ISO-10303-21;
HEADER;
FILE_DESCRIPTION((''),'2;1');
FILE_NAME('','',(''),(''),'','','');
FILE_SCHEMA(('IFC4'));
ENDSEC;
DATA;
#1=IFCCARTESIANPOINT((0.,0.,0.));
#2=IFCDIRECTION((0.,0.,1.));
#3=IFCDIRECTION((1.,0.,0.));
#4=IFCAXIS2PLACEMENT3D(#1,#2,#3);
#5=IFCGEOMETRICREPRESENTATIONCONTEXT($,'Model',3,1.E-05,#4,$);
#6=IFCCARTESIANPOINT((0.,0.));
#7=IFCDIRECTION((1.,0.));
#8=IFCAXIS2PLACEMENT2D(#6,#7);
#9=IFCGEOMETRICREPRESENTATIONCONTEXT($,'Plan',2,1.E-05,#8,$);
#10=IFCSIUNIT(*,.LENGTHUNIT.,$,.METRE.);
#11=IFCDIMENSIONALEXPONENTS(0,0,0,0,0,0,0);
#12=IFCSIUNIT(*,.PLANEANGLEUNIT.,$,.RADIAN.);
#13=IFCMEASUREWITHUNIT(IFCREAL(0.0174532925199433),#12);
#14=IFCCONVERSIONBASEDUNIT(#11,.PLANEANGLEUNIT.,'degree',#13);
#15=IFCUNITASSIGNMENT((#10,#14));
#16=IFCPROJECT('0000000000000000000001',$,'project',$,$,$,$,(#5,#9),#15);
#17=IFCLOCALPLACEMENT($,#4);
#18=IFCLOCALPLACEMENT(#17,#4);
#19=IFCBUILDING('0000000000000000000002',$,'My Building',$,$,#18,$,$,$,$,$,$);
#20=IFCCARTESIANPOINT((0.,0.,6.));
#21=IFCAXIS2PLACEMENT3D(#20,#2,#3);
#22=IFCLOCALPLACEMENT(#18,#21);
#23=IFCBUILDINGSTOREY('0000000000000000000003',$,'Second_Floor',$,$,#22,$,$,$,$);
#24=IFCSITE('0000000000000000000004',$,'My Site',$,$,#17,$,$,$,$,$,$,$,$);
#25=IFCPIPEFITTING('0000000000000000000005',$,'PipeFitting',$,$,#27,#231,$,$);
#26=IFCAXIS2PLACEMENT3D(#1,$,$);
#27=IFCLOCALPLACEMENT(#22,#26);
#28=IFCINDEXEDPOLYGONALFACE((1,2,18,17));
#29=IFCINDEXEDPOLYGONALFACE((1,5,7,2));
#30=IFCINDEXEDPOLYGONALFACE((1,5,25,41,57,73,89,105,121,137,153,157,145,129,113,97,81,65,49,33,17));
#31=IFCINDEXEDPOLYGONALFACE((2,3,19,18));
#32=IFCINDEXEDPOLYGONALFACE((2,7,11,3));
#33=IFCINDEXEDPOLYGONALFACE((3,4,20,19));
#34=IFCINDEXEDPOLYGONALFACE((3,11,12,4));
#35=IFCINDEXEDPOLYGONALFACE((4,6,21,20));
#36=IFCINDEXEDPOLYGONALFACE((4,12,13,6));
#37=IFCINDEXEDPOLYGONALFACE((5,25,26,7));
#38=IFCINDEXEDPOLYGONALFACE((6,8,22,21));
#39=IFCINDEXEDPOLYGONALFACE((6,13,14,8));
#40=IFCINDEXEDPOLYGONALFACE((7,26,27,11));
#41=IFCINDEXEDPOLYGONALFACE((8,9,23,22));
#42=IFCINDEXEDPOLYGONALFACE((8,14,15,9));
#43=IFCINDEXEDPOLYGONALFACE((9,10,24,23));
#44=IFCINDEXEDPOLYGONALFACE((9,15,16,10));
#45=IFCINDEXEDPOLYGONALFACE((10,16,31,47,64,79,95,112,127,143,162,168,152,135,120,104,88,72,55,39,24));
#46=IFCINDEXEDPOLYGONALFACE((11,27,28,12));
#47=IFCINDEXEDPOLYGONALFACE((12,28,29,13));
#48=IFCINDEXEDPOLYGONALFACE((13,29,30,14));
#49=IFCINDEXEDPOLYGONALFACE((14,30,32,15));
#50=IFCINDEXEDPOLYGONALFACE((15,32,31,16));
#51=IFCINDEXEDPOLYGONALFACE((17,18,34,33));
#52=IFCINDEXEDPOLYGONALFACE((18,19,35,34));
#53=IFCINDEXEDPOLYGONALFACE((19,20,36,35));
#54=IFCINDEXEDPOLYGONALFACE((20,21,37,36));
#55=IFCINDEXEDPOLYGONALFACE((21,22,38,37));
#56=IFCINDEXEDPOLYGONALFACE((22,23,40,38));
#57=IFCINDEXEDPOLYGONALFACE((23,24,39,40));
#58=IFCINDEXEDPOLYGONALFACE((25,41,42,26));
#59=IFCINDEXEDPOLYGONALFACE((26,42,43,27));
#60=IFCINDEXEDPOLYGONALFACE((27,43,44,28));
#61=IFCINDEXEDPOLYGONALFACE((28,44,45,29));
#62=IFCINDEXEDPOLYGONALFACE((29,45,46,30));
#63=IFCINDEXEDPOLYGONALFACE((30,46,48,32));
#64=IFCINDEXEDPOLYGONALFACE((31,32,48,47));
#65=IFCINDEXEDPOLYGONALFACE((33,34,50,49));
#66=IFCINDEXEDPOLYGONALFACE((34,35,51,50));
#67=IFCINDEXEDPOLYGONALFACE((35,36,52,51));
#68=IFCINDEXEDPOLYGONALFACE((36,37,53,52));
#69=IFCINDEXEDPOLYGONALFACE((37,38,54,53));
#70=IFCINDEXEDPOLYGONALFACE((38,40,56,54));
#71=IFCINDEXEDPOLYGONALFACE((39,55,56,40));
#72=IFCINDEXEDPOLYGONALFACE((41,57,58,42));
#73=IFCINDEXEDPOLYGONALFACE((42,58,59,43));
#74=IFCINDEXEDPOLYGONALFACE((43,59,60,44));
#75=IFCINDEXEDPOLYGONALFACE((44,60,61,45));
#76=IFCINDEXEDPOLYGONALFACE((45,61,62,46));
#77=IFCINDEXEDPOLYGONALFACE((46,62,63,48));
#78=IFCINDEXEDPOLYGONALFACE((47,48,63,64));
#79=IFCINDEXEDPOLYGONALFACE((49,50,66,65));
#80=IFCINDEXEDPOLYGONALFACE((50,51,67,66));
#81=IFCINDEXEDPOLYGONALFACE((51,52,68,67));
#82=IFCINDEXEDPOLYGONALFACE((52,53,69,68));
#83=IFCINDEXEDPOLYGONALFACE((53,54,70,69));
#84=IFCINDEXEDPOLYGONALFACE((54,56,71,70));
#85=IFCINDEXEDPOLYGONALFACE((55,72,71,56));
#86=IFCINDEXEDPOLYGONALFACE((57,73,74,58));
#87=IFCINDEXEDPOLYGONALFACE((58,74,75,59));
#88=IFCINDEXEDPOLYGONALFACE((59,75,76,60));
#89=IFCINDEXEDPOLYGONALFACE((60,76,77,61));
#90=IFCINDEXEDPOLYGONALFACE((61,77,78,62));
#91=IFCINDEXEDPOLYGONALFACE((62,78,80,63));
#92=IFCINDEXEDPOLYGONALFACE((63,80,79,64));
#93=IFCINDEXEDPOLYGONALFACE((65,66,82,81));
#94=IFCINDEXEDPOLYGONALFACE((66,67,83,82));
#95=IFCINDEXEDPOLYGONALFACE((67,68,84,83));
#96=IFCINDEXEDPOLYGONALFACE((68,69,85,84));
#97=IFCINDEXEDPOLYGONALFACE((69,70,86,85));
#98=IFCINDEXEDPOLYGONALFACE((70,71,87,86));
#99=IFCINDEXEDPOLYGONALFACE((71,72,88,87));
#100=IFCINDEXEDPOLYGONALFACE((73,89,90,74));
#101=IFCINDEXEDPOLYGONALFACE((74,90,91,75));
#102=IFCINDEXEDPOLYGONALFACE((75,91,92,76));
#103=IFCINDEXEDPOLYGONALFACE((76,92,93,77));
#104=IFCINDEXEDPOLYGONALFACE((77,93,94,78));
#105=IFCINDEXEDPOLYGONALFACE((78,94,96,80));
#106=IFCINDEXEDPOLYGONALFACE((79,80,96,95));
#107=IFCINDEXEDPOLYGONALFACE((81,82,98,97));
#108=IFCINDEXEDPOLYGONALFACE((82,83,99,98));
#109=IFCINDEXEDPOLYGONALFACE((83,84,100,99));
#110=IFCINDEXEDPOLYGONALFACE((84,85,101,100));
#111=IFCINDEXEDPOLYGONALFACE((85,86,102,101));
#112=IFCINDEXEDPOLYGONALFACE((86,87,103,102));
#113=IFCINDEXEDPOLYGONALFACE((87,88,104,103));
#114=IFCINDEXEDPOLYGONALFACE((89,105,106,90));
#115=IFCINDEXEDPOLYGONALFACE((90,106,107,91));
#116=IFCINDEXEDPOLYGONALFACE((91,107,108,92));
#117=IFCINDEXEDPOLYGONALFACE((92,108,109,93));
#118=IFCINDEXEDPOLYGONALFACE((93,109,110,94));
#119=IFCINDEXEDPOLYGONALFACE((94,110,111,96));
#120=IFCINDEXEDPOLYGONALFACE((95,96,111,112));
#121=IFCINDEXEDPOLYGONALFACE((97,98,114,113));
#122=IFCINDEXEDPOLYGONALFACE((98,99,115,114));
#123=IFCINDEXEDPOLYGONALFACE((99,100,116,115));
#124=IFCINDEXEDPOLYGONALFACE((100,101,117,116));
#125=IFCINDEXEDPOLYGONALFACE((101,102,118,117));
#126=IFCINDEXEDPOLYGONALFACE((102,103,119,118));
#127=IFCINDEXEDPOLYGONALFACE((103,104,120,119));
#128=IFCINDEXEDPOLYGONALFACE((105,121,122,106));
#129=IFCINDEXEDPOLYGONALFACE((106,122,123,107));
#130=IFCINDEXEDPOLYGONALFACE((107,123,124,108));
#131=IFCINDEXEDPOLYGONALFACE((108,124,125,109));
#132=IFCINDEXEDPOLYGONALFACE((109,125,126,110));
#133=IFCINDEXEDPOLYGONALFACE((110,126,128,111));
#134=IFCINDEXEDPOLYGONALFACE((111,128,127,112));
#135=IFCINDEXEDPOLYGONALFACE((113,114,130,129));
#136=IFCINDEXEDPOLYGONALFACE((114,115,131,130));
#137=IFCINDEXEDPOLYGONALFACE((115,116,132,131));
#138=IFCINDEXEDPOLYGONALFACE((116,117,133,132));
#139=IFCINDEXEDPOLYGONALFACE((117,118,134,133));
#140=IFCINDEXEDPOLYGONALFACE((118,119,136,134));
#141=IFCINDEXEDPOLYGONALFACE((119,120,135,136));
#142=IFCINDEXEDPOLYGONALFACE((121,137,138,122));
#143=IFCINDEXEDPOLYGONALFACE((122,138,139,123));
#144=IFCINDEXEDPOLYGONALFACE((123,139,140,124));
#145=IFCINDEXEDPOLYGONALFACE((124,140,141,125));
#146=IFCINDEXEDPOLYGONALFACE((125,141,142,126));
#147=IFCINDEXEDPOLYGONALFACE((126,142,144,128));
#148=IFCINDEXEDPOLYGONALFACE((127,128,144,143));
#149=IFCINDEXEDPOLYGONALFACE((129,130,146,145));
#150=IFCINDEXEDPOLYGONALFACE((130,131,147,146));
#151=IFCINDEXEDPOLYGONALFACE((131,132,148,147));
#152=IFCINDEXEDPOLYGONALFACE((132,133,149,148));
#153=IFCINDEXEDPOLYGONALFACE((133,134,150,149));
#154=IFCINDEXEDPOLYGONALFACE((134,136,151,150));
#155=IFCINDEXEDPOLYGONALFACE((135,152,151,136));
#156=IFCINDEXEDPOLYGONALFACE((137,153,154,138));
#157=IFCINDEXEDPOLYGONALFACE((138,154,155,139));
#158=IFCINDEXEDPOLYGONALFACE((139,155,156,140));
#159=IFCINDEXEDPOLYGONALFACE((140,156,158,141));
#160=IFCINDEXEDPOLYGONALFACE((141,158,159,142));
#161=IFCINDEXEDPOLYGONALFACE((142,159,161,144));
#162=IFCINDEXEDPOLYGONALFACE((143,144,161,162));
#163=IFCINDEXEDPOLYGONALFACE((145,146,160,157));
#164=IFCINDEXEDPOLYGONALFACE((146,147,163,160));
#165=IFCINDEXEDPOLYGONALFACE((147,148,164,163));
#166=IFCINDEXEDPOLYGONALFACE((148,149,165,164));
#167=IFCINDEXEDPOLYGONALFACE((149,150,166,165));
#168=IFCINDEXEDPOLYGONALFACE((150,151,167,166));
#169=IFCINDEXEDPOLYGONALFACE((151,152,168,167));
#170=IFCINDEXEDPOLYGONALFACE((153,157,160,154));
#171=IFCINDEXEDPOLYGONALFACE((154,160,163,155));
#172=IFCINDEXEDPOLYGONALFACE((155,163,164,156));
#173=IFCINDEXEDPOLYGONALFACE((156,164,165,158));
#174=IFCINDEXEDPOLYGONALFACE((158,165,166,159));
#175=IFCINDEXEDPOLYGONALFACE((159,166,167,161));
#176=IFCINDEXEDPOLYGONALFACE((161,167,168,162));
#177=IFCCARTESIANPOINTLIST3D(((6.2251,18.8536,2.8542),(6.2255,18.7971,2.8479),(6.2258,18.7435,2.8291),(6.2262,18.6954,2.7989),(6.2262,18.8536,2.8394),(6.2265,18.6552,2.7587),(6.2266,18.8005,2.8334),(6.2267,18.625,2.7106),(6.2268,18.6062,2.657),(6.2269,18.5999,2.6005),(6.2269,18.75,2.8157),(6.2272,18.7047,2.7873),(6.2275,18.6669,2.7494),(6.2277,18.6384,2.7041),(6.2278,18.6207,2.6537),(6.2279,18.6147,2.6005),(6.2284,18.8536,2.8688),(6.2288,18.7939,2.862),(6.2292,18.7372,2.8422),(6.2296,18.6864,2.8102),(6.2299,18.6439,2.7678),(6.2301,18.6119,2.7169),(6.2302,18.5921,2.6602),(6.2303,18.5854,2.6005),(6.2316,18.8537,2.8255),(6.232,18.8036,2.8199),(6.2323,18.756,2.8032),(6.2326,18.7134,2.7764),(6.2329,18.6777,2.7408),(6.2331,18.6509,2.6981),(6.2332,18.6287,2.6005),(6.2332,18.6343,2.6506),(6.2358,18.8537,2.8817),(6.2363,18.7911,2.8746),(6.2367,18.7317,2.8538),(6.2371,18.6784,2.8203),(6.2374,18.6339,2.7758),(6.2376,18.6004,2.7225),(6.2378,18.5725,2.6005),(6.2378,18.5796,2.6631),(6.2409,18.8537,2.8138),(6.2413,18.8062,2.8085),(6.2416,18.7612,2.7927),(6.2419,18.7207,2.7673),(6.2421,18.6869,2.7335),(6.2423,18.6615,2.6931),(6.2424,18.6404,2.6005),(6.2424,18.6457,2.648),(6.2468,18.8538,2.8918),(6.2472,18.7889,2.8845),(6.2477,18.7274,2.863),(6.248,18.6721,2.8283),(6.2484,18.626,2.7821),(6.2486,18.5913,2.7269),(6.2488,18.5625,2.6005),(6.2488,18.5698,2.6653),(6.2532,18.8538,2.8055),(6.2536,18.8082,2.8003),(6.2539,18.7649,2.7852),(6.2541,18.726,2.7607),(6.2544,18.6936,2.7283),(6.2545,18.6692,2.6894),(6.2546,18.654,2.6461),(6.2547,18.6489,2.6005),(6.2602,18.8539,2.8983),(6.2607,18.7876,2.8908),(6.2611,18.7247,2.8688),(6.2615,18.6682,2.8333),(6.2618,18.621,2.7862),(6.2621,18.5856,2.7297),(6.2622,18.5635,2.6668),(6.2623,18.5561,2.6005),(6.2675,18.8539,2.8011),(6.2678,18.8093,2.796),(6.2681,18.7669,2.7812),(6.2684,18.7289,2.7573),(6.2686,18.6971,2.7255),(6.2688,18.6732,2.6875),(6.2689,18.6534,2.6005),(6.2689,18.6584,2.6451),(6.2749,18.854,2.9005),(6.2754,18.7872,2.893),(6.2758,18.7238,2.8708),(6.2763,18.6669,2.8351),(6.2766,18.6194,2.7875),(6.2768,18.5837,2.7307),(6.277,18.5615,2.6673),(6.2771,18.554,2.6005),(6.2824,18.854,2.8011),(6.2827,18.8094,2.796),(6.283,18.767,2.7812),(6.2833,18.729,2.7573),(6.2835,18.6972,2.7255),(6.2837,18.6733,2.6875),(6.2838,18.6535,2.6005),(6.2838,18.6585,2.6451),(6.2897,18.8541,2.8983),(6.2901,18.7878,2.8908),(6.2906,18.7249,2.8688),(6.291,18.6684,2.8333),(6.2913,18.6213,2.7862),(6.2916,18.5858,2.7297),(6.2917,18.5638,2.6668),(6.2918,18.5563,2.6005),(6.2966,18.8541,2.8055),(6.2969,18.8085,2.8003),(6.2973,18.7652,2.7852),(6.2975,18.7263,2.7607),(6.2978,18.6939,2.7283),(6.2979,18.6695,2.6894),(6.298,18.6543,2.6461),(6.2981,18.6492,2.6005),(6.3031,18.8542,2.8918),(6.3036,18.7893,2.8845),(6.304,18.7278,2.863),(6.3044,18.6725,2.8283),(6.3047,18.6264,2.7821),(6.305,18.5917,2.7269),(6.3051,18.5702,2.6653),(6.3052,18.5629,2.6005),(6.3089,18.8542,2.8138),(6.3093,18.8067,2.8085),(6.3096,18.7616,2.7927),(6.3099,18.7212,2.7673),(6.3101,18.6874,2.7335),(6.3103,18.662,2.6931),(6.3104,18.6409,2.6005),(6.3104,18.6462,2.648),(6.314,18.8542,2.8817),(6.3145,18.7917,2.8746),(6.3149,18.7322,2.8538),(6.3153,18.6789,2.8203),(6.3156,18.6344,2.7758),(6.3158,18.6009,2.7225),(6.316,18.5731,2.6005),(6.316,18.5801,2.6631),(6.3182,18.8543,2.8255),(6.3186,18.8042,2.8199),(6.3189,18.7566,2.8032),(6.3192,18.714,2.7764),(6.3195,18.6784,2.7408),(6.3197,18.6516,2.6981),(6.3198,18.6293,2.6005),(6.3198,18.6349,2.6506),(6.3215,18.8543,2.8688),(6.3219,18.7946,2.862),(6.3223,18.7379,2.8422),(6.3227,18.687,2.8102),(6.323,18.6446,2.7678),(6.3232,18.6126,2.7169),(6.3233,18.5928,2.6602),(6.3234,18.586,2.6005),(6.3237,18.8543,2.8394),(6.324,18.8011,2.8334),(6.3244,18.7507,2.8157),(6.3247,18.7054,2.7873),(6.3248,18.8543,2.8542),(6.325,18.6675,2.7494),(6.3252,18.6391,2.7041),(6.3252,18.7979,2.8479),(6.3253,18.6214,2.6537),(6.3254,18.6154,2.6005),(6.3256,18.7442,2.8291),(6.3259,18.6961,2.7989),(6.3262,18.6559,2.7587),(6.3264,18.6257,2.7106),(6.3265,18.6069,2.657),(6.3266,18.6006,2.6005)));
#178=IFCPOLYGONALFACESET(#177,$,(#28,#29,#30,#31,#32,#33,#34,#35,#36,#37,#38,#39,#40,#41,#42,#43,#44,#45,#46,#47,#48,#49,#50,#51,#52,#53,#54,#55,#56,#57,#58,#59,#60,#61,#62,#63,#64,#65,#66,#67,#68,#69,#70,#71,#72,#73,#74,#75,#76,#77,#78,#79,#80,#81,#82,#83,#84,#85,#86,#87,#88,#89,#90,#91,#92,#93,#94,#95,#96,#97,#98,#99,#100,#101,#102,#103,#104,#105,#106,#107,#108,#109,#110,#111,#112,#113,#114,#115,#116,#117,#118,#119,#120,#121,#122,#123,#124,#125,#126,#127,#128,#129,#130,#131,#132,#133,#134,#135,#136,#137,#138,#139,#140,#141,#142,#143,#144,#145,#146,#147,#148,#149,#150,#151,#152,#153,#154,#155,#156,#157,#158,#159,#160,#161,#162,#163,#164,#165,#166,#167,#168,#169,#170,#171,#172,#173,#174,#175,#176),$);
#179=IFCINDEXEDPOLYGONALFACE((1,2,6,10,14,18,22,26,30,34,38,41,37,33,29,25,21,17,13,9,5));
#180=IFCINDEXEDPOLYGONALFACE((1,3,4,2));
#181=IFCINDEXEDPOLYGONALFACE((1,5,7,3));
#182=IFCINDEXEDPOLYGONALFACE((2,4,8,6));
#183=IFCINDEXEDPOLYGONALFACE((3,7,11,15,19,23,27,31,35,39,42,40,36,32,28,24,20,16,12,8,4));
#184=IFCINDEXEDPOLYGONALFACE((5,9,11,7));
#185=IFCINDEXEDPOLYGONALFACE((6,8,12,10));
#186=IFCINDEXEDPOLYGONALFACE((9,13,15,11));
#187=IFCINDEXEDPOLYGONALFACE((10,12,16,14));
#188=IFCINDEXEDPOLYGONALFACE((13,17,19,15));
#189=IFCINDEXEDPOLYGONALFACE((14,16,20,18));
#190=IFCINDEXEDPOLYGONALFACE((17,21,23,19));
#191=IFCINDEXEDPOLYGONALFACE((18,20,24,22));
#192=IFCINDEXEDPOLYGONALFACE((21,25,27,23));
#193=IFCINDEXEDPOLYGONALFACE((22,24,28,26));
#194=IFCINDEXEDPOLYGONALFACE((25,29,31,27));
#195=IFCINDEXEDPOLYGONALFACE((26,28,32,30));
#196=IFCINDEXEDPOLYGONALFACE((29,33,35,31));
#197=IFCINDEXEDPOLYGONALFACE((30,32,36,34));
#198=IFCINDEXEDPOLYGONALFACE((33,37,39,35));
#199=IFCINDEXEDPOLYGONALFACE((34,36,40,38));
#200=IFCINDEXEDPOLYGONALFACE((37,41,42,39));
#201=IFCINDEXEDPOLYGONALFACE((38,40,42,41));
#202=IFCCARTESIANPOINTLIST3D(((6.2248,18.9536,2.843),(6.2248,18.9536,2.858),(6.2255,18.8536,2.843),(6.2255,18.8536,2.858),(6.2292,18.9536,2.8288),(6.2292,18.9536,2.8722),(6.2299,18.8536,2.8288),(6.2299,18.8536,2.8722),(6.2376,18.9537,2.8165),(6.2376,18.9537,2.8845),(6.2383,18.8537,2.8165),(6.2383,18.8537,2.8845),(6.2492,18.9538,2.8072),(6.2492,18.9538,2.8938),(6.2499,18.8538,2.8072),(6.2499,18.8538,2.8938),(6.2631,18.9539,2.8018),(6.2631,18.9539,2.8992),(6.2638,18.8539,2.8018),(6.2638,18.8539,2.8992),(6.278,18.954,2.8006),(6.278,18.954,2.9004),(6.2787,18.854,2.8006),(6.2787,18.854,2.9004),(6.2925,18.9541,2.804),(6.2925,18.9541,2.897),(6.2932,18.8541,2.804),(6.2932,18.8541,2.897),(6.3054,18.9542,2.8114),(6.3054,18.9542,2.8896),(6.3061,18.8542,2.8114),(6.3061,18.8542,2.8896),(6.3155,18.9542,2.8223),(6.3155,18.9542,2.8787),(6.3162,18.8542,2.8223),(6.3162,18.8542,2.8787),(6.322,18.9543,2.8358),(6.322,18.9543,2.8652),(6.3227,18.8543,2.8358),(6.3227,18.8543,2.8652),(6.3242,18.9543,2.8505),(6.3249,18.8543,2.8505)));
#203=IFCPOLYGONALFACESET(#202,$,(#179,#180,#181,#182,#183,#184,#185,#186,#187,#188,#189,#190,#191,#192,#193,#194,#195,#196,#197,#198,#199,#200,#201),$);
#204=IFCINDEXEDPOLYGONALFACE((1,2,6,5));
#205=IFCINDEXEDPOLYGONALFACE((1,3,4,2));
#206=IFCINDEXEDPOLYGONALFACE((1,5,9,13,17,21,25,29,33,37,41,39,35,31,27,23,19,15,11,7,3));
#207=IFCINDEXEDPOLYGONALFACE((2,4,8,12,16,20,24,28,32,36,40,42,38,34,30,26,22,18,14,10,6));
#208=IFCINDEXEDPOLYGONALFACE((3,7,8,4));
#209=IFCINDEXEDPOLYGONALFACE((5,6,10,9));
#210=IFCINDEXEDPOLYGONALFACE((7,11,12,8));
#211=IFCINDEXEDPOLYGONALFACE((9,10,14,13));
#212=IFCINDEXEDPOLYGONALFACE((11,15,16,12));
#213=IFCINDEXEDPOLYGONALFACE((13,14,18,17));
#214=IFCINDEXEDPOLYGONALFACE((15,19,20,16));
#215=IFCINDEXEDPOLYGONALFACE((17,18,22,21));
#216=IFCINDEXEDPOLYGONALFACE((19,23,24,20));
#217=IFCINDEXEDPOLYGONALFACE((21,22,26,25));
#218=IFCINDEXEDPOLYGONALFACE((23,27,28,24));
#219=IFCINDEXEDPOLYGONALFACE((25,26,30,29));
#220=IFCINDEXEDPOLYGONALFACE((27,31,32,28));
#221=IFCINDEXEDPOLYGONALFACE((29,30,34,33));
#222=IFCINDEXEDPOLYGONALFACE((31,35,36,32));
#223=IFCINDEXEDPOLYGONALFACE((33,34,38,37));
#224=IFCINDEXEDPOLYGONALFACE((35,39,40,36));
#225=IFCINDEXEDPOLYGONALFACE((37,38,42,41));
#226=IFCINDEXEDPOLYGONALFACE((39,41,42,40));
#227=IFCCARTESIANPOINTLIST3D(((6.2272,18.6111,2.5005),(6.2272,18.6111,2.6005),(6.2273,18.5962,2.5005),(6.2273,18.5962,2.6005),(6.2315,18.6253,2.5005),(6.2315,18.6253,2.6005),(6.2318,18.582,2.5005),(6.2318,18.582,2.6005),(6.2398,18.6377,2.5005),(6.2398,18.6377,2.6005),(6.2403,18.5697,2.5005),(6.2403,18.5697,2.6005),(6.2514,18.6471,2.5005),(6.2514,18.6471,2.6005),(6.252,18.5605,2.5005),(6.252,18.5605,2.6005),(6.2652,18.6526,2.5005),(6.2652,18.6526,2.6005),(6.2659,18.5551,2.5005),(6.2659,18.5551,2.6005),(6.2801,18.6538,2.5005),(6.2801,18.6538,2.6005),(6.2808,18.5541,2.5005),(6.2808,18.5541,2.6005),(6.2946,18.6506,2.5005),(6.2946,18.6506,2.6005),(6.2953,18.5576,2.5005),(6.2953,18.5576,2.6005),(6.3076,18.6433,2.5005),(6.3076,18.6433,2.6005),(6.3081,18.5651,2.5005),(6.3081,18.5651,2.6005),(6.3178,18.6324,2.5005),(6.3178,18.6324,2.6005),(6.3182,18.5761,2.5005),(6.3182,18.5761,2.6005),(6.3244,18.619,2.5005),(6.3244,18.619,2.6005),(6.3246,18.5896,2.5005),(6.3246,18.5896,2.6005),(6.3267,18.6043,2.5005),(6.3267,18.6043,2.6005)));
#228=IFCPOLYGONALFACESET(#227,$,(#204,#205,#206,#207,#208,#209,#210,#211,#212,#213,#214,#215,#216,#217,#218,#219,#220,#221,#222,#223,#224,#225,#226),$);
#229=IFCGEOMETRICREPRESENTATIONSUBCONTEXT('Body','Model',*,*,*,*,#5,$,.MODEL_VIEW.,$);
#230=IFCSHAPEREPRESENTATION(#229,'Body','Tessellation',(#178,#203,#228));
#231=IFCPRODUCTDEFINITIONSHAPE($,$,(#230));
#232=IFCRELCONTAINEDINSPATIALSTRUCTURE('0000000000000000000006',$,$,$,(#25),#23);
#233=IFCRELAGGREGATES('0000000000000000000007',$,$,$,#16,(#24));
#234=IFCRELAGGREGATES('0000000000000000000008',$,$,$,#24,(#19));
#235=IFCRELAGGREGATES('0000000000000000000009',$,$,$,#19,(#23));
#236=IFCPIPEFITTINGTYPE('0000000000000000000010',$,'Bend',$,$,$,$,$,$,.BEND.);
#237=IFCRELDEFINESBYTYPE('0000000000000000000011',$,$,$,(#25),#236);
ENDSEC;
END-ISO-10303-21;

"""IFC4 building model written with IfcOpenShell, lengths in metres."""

from ifc_helpers import new_model, entity, si_unit, converted_unit, frame, origin_with_axes, origin_2d_with_axis, place, context, subcontext, project, spatial, circle, extrude, source, transform, mapped, type_object, type_shapes, element, save


model = new_model("IFC4")

# Units and contexts
model_context = context("Model", 3, precision=1e-05, world=origin_with_axes())
plan_context = context("Plan", 2, precision=1e-05, world=origin_2d_with_axis())
body_context_1 = subcontext(model_context, "Body", "Model", "MODEL_VIEW")
ifc_project = project(units=[si_unit("LENGTHUNIT", "METRE"), converted_unit("PLANEANGLEUNIT", "degree", entity("IfcReal", 0.0174532925199433), si_unit("PLANEANGLEUNIT", "RADIAN"), dimensions=[0, 0, 0, 0, 0, 0, 0])], contexts=[model_context, plan_context])

# Site, building, storey
site_placement = place(None, origin_with_axes())
site = spatial("IfcSite", under=ifc_project, at=site_placement, Name="My Site")
building_placement = place(site_placement, origin_with_axes())
building = spatial("IfcBuilding", under=site, at=building_placement, Name="My Building")
storey_placement = place(building_placement, frame((0.0, 0.0, 6.0), z_axis=(0.0, 0.0, 1.0), x_axis=(1.0, 0.0, 0.0)))
storey = spatial("IfcBuildingStorey", under=building, at=storey_placement, Name="Second_Floor")

# Pipe fitting
pipe_fitting_type = type_object("IfcPipeFittingType", Name="Bend", PredefinedType="BEND")
shared_shape_1 = source(origin_with_axes(), body_context_1, "Body", "SolidModel", [
    entity("IfcSweptDiskSolid", entity("IfcIndexedPolyCurve", entity("IfcCartesianPointList3D", [[0.0, 0.0, -0.1], [0.0, 0.0732, -0.2768], [0.0, 0.25, -0.35]]), [entity("IfcArcIndex", [1, 2, 3])]), 0.05),
    extrude(circle(Radius=0.05), origin_with_axes(), (0.0, 0.0, -1.0), 0.1),
    extrude(circle(Radius=0.05), frame((0.0, 0.25, -0.35), z_axis=(0.0, 1.0, 0.0), x_axis=(1.0, 0.0, 0.0)), (0.0, 0.0, 1.0), 0.1),
])
type_shapes(pipe_fitting_type, [shared_shape_1])
pipe_fitting_placement = place(storey_placement, frame((6.2742, 18.954, 2.8505), z_axis=(-0.007084, 0.999975, 0.0), x_axis=(0.999975, 0.007084, 0.0)))
element("IfcPipeFitting", 1, at=pipe_fitting_placement, inside=storey, type_object=pipe_fitting_type, Name="PipeFitting", context=body_context_1, shape_type="MappedRepresentation", body=[
    mapped(shared_shape_1, transform((0.0, 0.0, 0.0), x_axis=(1.0, 0.0, 0.0), y_axis=(0.0, 1.0, 0.0), z_axis=(0.0, 0.0, 1.0), scale=1.0)),
])

save(model, "model.ifc")
